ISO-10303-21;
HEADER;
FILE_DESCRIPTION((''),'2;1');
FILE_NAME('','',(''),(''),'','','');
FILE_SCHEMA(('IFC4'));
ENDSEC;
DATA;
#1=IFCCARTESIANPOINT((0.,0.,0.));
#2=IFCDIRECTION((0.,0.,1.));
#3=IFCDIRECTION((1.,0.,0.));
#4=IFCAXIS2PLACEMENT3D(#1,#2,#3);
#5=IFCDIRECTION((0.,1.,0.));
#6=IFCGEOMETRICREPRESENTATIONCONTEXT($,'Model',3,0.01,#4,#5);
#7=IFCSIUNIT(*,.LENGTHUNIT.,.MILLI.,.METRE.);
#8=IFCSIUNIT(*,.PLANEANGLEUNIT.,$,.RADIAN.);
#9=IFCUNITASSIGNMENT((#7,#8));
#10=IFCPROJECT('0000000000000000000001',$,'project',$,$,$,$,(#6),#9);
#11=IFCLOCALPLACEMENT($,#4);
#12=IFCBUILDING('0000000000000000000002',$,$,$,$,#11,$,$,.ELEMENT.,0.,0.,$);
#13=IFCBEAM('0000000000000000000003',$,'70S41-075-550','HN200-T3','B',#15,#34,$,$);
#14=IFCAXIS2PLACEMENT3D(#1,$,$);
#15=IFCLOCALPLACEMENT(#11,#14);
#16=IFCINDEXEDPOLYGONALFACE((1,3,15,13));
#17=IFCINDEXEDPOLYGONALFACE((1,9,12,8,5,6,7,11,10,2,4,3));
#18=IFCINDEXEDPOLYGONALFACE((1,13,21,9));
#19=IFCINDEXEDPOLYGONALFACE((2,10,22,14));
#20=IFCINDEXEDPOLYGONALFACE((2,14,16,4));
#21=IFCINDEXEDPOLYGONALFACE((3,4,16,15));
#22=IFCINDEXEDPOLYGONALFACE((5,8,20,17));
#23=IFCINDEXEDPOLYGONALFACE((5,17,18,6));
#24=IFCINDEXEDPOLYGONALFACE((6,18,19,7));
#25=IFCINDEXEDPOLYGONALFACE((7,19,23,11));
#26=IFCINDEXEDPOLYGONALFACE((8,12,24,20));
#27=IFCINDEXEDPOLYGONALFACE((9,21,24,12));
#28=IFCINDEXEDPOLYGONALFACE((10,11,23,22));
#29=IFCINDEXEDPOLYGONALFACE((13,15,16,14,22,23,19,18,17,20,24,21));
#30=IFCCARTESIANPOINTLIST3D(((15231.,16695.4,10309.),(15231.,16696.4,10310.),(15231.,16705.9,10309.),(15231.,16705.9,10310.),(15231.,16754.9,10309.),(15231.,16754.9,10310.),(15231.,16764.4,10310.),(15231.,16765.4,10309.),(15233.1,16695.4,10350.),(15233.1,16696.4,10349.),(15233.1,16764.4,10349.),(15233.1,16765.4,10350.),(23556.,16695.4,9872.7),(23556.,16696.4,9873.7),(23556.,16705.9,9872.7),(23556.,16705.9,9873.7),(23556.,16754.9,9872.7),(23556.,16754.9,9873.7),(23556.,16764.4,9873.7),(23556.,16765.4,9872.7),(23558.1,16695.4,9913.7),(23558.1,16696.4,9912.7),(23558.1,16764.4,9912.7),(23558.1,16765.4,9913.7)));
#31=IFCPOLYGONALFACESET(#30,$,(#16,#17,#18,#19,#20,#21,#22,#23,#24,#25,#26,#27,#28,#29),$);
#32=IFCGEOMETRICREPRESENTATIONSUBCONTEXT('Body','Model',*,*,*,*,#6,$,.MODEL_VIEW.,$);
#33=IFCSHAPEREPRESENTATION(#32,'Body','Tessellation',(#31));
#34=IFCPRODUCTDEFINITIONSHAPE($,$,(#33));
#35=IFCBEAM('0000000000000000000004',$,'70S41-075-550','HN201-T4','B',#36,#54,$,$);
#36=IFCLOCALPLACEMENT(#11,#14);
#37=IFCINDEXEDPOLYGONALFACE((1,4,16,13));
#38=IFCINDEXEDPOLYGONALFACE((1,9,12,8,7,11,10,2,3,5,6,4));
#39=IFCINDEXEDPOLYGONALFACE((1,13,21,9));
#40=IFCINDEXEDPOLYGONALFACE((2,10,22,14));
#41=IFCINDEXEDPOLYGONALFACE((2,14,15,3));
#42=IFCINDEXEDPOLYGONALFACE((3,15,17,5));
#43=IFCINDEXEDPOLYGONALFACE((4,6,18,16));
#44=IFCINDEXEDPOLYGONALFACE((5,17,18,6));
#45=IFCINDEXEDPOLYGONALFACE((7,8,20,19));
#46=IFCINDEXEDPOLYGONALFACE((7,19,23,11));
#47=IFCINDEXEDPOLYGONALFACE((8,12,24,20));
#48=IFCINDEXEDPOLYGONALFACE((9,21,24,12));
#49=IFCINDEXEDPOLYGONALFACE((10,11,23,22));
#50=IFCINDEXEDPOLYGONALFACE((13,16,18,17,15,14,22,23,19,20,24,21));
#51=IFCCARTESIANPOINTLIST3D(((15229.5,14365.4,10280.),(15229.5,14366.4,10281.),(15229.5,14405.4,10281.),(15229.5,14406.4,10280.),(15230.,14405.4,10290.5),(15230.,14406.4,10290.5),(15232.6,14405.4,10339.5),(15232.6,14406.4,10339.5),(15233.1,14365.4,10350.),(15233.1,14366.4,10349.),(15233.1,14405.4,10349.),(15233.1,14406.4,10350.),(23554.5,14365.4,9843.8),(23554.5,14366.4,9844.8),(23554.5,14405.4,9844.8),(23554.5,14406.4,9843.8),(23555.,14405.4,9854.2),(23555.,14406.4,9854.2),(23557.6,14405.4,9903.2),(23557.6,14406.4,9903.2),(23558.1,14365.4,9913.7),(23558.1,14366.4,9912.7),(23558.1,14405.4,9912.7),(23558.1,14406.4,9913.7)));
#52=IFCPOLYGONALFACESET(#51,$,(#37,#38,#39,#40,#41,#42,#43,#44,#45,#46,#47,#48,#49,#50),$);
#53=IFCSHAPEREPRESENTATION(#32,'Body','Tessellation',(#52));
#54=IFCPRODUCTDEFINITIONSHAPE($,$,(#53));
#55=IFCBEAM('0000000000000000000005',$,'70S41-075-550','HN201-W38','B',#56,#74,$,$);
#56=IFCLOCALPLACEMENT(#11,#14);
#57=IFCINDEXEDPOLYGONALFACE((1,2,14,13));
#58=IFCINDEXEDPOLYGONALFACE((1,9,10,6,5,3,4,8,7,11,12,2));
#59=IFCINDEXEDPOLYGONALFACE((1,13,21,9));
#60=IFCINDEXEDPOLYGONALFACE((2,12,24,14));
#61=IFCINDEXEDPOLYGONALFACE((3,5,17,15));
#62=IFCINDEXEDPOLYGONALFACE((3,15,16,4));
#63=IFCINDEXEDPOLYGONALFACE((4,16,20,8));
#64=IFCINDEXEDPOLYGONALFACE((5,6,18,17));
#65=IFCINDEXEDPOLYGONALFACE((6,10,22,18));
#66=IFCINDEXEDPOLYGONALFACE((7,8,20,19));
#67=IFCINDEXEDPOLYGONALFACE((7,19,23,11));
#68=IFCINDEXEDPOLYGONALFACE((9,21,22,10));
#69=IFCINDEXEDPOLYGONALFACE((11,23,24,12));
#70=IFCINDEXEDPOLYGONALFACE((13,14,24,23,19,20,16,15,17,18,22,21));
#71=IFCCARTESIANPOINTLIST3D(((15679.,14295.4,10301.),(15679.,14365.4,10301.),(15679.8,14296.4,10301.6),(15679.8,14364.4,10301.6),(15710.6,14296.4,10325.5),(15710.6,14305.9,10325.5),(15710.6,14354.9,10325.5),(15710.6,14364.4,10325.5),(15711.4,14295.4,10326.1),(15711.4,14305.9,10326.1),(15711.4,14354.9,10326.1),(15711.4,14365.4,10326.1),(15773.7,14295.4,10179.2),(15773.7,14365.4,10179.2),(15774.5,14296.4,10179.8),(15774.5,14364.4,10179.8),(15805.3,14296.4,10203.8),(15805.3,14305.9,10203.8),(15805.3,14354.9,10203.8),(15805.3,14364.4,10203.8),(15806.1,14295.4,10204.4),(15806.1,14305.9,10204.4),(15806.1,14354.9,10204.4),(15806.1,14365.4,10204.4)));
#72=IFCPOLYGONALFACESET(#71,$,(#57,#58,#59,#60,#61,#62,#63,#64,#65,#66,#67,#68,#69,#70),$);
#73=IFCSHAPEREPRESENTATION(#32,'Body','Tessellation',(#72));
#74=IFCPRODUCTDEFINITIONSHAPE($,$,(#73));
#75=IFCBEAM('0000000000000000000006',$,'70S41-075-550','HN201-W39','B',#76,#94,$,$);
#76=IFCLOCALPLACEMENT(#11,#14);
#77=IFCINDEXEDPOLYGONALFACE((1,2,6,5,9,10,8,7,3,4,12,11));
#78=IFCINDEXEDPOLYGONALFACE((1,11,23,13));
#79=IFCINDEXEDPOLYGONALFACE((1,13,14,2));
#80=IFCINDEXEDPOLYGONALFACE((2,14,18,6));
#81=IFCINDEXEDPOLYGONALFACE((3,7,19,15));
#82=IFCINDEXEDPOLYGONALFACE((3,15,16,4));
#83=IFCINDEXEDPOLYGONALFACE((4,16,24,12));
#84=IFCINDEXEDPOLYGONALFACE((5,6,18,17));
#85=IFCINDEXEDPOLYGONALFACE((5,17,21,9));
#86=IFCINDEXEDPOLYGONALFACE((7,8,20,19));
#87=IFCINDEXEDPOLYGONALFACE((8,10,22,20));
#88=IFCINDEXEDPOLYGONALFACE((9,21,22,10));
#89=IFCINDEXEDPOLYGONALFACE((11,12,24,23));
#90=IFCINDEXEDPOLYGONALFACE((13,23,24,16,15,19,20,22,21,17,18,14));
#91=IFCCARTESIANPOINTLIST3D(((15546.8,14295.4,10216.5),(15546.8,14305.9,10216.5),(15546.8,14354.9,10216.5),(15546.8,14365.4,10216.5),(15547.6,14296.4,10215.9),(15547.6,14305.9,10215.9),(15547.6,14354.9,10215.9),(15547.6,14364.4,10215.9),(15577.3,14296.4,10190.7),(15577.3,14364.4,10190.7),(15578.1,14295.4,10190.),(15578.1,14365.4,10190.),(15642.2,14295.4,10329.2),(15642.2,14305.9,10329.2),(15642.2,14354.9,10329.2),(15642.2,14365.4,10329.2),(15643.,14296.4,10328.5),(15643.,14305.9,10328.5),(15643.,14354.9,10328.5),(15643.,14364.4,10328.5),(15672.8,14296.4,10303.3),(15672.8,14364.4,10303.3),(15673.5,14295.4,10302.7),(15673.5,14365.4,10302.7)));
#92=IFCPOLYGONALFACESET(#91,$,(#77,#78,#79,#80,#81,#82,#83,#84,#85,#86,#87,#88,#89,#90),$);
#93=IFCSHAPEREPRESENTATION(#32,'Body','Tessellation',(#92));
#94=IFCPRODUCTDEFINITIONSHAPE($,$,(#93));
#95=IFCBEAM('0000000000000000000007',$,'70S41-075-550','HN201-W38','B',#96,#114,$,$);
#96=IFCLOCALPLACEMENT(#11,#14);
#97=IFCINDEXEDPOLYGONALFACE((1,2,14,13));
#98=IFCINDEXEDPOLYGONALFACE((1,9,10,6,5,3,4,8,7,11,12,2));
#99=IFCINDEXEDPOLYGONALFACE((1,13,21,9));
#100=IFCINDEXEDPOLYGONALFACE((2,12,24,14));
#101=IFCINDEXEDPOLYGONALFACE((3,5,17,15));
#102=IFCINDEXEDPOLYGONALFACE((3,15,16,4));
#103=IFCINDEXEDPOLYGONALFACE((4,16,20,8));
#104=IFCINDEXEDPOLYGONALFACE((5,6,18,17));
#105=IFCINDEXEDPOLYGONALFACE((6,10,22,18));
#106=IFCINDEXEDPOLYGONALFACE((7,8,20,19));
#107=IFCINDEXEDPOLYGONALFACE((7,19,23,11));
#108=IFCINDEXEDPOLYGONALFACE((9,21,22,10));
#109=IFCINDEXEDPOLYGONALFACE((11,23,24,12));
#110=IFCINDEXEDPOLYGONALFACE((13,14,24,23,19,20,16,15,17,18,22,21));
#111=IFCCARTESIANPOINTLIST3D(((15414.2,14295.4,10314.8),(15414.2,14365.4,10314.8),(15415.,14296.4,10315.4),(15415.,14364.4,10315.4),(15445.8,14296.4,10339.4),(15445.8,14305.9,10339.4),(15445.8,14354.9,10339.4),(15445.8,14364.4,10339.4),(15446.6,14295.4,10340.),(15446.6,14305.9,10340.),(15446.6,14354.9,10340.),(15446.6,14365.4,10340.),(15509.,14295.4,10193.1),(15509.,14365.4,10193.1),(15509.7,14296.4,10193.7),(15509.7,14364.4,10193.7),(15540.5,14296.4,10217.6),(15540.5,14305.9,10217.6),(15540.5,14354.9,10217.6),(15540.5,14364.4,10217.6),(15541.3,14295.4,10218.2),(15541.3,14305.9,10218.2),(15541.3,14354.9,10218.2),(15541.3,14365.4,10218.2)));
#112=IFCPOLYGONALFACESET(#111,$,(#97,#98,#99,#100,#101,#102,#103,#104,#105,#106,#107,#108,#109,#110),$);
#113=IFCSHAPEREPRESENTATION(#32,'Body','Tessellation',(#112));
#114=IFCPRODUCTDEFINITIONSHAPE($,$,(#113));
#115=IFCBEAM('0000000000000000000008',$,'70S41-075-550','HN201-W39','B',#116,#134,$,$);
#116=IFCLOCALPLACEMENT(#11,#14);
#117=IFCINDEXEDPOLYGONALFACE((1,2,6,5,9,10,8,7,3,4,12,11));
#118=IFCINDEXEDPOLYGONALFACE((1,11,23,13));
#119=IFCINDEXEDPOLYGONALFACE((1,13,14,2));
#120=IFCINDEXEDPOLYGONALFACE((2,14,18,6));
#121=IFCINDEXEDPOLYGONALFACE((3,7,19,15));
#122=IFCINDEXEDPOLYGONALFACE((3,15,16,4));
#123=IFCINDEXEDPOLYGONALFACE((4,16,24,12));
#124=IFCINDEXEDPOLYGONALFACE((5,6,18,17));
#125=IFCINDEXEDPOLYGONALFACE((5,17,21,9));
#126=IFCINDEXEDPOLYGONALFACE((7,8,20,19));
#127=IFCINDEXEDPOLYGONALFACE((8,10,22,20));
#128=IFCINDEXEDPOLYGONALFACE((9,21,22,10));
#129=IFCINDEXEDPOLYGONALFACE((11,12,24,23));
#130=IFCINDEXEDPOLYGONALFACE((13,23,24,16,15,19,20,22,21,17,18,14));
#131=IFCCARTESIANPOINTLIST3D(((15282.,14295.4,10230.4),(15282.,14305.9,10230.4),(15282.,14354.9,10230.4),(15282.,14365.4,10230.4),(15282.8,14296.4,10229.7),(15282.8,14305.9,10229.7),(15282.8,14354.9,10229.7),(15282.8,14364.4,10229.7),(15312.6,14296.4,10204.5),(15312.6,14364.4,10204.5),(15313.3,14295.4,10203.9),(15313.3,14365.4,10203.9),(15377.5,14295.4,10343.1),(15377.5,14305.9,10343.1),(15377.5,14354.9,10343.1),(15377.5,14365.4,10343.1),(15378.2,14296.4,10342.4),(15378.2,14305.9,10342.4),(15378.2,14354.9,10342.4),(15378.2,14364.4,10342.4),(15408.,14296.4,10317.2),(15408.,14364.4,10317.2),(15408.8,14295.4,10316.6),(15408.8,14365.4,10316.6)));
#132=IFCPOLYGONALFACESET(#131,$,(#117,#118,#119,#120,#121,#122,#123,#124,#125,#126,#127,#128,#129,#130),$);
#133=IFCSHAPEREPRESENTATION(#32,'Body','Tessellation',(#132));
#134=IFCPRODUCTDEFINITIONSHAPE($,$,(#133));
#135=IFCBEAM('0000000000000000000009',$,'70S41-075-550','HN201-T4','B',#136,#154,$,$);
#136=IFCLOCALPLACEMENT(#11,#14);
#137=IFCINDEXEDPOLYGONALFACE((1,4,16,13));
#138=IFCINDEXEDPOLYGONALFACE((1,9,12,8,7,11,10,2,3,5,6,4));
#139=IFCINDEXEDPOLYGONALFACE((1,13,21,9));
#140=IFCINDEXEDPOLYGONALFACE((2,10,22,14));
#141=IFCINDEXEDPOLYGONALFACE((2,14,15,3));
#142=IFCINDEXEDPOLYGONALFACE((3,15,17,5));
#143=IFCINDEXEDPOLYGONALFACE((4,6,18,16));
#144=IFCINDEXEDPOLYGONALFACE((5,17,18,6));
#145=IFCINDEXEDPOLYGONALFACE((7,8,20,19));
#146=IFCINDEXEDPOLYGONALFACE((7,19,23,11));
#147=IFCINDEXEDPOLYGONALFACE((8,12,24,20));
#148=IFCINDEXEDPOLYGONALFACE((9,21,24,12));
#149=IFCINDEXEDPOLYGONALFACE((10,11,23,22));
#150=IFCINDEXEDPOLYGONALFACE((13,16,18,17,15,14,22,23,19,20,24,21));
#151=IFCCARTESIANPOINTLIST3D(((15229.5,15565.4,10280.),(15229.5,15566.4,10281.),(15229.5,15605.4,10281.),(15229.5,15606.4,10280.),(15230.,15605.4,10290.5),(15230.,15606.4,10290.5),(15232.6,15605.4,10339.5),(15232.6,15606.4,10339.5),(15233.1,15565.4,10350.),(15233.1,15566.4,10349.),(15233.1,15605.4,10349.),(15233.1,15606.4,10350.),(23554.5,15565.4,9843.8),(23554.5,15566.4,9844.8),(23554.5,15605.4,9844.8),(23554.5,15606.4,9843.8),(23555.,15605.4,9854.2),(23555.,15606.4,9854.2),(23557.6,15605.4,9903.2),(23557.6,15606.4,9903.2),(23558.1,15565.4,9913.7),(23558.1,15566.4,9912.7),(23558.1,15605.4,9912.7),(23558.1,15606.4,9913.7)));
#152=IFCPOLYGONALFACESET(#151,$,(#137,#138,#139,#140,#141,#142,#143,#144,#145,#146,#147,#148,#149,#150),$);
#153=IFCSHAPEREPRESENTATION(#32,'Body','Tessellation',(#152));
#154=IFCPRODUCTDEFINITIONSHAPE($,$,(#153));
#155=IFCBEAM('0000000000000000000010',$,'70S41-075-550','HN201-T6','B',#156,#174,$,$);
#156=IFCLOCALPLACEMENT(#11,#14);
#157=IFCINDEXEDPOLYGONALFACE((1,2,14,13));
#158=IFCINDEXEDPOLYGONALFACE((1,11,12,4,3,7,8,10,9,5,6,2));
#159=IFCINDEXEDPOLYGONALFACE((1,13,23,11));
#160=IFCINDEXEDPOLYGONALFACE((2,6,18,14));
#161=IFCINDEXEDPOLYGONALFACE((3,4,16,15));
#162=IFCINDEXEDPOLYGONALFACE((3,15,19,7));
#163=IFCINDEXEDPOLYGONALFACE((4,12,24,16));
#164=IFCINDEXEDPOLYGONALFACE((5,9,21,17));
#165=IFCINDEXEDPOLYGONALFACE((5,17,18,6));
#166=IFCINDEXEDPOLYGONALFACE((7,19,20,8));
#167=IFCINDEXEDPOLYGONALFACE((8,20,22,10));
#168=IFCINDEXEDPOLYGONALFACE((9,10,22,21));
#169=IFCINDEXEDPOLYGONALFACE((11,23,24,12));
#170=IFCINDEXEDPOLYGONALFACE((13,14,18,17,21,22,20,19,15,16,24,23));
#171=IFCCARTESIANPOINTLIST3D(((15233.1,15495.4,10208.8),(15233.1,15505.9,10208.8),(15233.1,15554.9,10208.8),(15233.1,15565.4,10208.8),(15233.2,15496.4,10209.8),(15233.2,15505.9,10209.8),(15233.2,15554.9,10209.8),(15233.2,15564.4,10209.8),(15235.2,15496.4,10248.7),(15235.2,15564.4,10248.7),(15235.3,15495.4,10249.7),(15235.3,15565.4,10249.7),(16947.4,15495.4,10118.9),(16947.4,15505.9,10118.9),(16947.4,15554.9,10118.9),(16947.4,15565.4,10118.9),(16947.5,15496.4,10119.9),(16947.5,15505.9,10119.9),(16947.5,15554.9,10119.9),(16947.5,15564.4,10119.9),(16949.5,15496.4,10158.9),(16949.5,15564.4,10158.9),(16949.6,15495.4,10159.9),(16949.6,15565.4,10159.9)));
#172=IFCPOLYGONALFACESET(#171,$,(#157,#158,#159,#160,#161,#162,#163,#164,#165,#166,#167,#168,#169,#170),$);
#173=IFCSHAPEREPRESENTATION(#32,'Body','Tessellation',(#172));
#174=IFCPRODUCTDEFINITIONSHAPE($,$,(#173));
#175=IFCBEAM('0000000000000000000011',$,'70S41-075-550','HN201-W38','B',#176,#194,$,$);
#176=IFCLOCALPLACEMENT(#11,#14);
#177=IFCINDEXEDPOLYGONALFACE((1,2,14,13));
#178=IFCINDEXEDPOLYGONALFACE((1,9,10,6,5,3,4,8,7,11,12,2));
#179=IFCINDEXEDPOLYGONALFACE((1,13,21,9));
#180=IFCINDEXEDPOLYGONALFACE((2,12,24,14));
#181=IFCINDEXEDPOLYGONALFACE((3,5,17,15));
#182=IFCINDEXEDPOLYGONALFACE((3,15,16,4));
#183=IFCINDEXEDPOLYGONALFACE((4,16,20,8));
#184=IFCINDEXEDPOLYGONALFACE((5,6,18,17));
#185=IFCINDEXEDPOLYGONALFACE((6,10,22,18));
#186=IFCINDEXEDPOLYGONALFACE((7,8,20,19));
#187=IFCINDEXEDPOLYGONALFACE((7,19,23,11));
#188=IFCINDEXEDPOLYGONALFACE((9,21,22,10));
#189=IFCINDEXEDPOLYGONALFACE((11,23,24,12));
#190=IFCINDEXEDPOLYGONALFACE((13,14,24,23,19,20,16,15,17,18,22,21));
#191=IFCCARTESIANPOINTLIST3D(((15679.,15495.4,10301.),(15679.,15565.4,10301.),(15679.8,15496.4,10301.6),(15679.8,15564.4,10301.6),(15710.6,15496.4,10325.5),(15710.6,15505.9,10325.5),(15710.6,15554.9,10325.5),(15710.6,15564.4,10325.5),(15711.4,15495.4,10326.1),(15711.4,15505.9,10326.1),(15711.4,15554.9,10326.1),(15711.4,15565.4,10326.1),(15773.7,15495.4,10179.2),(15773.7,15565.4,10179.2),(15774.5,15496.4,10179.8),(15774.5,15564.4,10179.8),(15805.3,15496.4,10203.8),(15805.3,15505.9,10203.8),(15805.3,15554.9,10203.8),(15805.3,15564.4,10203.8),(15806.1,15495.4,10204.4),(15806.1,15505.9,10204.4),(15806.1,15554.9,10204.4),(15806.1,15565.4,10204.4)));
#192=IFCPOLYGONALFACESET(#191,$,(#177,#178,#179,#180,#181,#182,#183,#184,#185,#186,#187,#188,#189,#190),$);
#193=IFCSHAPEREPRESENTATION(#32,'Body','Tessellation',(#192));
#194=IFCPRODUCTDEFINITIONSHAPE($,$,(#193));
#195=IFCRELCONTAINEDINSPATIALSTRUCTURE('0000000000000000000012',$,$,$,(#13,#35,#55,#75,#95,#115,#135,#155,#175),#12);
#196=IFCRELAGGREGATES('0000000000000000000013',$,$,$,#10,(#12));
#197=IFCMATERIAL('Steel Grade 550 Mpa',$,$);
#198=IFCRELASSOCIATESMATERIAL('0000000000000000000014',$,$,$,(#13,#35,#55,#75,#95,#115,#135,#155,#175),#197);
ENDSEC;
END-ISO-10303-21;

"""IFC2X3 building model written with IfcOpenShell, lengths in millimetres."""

from ifc_helpers import new_model, si_unit, direction, frame, origin, origin_with_axes, origin_2d_with_axis, place, context, subcontext, project, spatial, c_section, extrude, source, transform, mapped, material, element, save


model = new_model("IFC2X3")

# Units and contexts
model_context = context("Model", 3, precision=0.01, world=origin_with_axes(), true_north=direction((0.0, 1.0, 0.0)))
body_context = subcontext(model_context, "Body", "Model", "MODEL_VIEW")
ifc_project = project(units=[si_unit("LENGTHUNIT", "METRE", prefix="MILLI"), si_unit("PLANEANGLEUNIT", "RADIAN")], contexts=[model_context])

# Building
building_placement = place(None, origin_with_axes())
building = spatial("IfcBuilding", under=ifc_project, at=building_placement, CompositionType="ELEMENT", ElevationOfRefHeight=0.0, ElevationOfTerrain=0.0)

# Shared definitions
ifc_material = material(Name="Steel Grade 550 Mpa")

# Beams
shared_shape_1 = source(origin(), body_context, "Body", "SweptSolid", [
    extrude(c_section(Depth=70.0, Width=41.0, WallThickness=1.0, Girth=10.5, at=origin_2d_with_axis()), origin_with_axes(), (0.0, 0.0, 1.0), 8336.4),
])
beam_1_placement = place(None, frame((15232.0, 16730.4, 10329.5), z_axis=(0.99863, 0.0, -0.052336), x_axis=(-0.052336, 0.0, -0.99863)))
element("IfcBeam", 1, at=beam_1_placement, inside=building, material=ifc_material, Name="70S41-075-550", Description="HN200-T3", ObjectType="B", context=body_context, shape_type="MappedRepresentation", body=[
    mapped(shared_shape_1, transform((0.0, 0.0, 0.0), scale=1.0)),
])
shared_shape_2 = source(origin(), body_context, "Body", "SweptSolid", [
    extrude(c_section(Depth=70.0, Width=41.0, WallThickness=1.0, Girth=10.5, at=origin_2d_with_axis()), origin_with_axes(), (0.0, 0.0, 1.0), 8336.4),
])
beam_2_placement = place(None, frame((15231.3, 14385.9, 10315.0), z_axis=(0.99863, 0.0, -0.052336), x_axis=(0.0, 1.0, 0.0)))
element("IfcBeam", 2, at=beam_2_placement, inside=building, material=ifc_material, Name="70S41-075-550", Description="HN201-T4", ObjectType="B", context=body_context, shape_type="MappedRepresentation", body=[
    mapped(shared_shape_2, transform((0.0, 0.0, 0.0), scale=1.0)),
])
shared_shape_3 = source(origin(), body_context, "Body", "SweptSolid", [
    extrude(c_section(Depth=70.0, Width=41.0, WallThickness=1.0, Girth=10.5, at=origin_2d_with_axis()), origin_with_axes(), (0.0, 0.0, 1.0), 154.3),
])
beam_3_placement = place(None, frame((15789.9, 14330.4, 10191.8), z_axis=(-0.613981, 0.0, 0.789321), x_axis=(0.789321, 0.0, 0.613981)))
element("IfcBeam", 3, at=beam_3_placement, inside=building, material=ifc_material, Name="70S41-075-550", Description="HN201-W38", ObjectType="B", context=body_context, shape_type="MappedRepresentation", body=[
    mapped(shared_shape_3, transform((0.0, 0.0, 0.0), scale=1.0)),
])
shared_shape_4 = source(origin(), body_context, "Body", "SweptSolid", [
    extrude(c_section(Depth=70.0, Width=41.0, WallThickness=1.0, Girth=10.5, at=origin_2d_with_axis()), origin_with_axes(), (0.0, 0.0, 1.0), 147.6),
])
beam_4_placement = place(None, frame((15657.9, 14330.4, 10315.9), z_axis=(-0.646275, 0.0, -0.763105), x_axis=(-0.763105, 0.0, 0.646275)))
element("IfcBeam", 4, at=beam_4_placement, inside=building, material=ifc_material, Name="70S41-075-550", Description="HN201-W39", ObjectType="B", context=body_context, shape_type="MappedRepresentation", body=[
    mapped(shared_shape_4, transform((0.0, 0.0, 0.0), scale=1.0)),
])
shared_shape_5 = source(origin(), body_context, "Body", "SweptSolid", [
    extrude(c_section(Depth=70.0, Width=41.0, WallThickness=1.0, Girth=10.5, at=origin_2d_with_axis()), origin_with_axes(), (0.0, 0.0, 1.0), 154.3),
])
beam_5_placement = place(None, frame((15525.1, 14330.4, 10205.7), z_axis=(-0.613981, 0.0, 0.789321), x_axis=(0.789321, 0.0, 0.613981)))
element("IfcBeam", 5, at=beam_5_placement, inside=building, material=ifc_material, Name="70S41-075-550", Description="HN201-W38", ObjectType="B", context=body_context, shape_type="MappedRepresentation", body=[
    mapped(shared_shape_5, transform((0.0, 0.0, 0.0), scale=1.0)),
])
shared_shape_6 = source(origin(), body_context, "Body", "SweptSolid", [
    extrude(c_section(Depth=70.0, Width=41.0, WallThickness=1.0, Girth=10.5, at=origin_2d_with_axis()), origin_with_axes(), (0.0, 0.0, 1.0), 147.6),
])
beam_6_placement = place(None, frame((15393.1, 14330.4, 10329.8), z_axis=(-0.646275, 0.0, -0.763105), x_axis=(-0.763105, 0.0, 0.646275)))
element("IfcBeam", 6, at=beam_6_placement, inside=building, material=ifc_material, Name="70S41-075-550", Description="HN201-W39", ObjectType="B", context=body_context, shape_type="MappedRepresentation", body=[
    mapped(shared_shape_6, transform((0.0, 0.0, 0.0), scale=1.0)),
])
shared_shape_7 = source(origin(), body_context, "Body", "SweptSolid", [
    extrude(c_section(Depth=70.0, Width=41.0, WallThickness=1.0, Girth=10.5, at=origin_2d_with_axis()), origin_with_axes(), (0.0, 0.0, 1.0), 8336.4),
])
beam_7_placement = place(None, frame((15231.3, 15585.9, 10315.0), z_axis=(0.99863, 0.0, -0.052336), x_axis=(0.0, 1.0, 0.0)))
element("IfcBeam", 7, at=beam_7_placement, inside=building, material=ifc_material, Name="70S41-075-550", Description="HN201-T4", ObjectType="B", context=body_context, shape_type="MappedRepresentation", body=[
    mapped(shared_shape_7, transform((0.0, 0.0, 0.0), scale=1.0)),
])
shared_shape_8 = source(origin(), body_context, "Body", "SweptSolid", [
    extrude(c_section(Depth=70.0, Width=41.0, WallThickness=1.0, Girth=10.5, at=origin_2d_with_axis()), origin_with_axes(), (0.0, 0.0, 1.0), 1716.6),
])
beam_8_placement = place(None, frame((15234.2, 15530.4, 10229.2), z_axis=(0.99863, 0.0, -0.052336), x_axis=(-0.052336, 0.0, -0.99863)))
element("IfcBeam", 8, at=beam_8_placement, inside=building, material=ifc_material, Name="70S41-075-550", Description="HN201-T6", ObjectType="B", context=body_context, shape_type="MappedRepresentation", body=[
    mapped(shared_shape_8, transform((0.0, 0.0, 0.0), scale=1.0)),
])
shared_shape_9 = source(origin(), body_context, "Body", "SweptSolid", [
    extrude(c_section(Depth=70.0, Width=41.0, WallThickness=1.0, Girth=10.5, at=origin_2d_with_axis()), origin_with_axes(), (0.0, 0.0, 1.0), 154.3),
])
beam_9_placement = place(None, frame((15789.9, 15530.4, 10191.8), z_axis=(-0.613981, 0.0, 0.789321), x_axis=(0.789321, 0.0, 0.613981)))
element("IfcBeam", 9, at=beam_9_placement, inside=building, material=ifc_material, Name="70S41-075-550", Description="HN201-W38", ObjectType="B", context=body_context, shape_type="MappedRepresentation", body=[
    mapped(shared_shape_9, transform((0.0, 0.0, 0.0), scale=1.0)),
])

save(model, "model.ifc")
